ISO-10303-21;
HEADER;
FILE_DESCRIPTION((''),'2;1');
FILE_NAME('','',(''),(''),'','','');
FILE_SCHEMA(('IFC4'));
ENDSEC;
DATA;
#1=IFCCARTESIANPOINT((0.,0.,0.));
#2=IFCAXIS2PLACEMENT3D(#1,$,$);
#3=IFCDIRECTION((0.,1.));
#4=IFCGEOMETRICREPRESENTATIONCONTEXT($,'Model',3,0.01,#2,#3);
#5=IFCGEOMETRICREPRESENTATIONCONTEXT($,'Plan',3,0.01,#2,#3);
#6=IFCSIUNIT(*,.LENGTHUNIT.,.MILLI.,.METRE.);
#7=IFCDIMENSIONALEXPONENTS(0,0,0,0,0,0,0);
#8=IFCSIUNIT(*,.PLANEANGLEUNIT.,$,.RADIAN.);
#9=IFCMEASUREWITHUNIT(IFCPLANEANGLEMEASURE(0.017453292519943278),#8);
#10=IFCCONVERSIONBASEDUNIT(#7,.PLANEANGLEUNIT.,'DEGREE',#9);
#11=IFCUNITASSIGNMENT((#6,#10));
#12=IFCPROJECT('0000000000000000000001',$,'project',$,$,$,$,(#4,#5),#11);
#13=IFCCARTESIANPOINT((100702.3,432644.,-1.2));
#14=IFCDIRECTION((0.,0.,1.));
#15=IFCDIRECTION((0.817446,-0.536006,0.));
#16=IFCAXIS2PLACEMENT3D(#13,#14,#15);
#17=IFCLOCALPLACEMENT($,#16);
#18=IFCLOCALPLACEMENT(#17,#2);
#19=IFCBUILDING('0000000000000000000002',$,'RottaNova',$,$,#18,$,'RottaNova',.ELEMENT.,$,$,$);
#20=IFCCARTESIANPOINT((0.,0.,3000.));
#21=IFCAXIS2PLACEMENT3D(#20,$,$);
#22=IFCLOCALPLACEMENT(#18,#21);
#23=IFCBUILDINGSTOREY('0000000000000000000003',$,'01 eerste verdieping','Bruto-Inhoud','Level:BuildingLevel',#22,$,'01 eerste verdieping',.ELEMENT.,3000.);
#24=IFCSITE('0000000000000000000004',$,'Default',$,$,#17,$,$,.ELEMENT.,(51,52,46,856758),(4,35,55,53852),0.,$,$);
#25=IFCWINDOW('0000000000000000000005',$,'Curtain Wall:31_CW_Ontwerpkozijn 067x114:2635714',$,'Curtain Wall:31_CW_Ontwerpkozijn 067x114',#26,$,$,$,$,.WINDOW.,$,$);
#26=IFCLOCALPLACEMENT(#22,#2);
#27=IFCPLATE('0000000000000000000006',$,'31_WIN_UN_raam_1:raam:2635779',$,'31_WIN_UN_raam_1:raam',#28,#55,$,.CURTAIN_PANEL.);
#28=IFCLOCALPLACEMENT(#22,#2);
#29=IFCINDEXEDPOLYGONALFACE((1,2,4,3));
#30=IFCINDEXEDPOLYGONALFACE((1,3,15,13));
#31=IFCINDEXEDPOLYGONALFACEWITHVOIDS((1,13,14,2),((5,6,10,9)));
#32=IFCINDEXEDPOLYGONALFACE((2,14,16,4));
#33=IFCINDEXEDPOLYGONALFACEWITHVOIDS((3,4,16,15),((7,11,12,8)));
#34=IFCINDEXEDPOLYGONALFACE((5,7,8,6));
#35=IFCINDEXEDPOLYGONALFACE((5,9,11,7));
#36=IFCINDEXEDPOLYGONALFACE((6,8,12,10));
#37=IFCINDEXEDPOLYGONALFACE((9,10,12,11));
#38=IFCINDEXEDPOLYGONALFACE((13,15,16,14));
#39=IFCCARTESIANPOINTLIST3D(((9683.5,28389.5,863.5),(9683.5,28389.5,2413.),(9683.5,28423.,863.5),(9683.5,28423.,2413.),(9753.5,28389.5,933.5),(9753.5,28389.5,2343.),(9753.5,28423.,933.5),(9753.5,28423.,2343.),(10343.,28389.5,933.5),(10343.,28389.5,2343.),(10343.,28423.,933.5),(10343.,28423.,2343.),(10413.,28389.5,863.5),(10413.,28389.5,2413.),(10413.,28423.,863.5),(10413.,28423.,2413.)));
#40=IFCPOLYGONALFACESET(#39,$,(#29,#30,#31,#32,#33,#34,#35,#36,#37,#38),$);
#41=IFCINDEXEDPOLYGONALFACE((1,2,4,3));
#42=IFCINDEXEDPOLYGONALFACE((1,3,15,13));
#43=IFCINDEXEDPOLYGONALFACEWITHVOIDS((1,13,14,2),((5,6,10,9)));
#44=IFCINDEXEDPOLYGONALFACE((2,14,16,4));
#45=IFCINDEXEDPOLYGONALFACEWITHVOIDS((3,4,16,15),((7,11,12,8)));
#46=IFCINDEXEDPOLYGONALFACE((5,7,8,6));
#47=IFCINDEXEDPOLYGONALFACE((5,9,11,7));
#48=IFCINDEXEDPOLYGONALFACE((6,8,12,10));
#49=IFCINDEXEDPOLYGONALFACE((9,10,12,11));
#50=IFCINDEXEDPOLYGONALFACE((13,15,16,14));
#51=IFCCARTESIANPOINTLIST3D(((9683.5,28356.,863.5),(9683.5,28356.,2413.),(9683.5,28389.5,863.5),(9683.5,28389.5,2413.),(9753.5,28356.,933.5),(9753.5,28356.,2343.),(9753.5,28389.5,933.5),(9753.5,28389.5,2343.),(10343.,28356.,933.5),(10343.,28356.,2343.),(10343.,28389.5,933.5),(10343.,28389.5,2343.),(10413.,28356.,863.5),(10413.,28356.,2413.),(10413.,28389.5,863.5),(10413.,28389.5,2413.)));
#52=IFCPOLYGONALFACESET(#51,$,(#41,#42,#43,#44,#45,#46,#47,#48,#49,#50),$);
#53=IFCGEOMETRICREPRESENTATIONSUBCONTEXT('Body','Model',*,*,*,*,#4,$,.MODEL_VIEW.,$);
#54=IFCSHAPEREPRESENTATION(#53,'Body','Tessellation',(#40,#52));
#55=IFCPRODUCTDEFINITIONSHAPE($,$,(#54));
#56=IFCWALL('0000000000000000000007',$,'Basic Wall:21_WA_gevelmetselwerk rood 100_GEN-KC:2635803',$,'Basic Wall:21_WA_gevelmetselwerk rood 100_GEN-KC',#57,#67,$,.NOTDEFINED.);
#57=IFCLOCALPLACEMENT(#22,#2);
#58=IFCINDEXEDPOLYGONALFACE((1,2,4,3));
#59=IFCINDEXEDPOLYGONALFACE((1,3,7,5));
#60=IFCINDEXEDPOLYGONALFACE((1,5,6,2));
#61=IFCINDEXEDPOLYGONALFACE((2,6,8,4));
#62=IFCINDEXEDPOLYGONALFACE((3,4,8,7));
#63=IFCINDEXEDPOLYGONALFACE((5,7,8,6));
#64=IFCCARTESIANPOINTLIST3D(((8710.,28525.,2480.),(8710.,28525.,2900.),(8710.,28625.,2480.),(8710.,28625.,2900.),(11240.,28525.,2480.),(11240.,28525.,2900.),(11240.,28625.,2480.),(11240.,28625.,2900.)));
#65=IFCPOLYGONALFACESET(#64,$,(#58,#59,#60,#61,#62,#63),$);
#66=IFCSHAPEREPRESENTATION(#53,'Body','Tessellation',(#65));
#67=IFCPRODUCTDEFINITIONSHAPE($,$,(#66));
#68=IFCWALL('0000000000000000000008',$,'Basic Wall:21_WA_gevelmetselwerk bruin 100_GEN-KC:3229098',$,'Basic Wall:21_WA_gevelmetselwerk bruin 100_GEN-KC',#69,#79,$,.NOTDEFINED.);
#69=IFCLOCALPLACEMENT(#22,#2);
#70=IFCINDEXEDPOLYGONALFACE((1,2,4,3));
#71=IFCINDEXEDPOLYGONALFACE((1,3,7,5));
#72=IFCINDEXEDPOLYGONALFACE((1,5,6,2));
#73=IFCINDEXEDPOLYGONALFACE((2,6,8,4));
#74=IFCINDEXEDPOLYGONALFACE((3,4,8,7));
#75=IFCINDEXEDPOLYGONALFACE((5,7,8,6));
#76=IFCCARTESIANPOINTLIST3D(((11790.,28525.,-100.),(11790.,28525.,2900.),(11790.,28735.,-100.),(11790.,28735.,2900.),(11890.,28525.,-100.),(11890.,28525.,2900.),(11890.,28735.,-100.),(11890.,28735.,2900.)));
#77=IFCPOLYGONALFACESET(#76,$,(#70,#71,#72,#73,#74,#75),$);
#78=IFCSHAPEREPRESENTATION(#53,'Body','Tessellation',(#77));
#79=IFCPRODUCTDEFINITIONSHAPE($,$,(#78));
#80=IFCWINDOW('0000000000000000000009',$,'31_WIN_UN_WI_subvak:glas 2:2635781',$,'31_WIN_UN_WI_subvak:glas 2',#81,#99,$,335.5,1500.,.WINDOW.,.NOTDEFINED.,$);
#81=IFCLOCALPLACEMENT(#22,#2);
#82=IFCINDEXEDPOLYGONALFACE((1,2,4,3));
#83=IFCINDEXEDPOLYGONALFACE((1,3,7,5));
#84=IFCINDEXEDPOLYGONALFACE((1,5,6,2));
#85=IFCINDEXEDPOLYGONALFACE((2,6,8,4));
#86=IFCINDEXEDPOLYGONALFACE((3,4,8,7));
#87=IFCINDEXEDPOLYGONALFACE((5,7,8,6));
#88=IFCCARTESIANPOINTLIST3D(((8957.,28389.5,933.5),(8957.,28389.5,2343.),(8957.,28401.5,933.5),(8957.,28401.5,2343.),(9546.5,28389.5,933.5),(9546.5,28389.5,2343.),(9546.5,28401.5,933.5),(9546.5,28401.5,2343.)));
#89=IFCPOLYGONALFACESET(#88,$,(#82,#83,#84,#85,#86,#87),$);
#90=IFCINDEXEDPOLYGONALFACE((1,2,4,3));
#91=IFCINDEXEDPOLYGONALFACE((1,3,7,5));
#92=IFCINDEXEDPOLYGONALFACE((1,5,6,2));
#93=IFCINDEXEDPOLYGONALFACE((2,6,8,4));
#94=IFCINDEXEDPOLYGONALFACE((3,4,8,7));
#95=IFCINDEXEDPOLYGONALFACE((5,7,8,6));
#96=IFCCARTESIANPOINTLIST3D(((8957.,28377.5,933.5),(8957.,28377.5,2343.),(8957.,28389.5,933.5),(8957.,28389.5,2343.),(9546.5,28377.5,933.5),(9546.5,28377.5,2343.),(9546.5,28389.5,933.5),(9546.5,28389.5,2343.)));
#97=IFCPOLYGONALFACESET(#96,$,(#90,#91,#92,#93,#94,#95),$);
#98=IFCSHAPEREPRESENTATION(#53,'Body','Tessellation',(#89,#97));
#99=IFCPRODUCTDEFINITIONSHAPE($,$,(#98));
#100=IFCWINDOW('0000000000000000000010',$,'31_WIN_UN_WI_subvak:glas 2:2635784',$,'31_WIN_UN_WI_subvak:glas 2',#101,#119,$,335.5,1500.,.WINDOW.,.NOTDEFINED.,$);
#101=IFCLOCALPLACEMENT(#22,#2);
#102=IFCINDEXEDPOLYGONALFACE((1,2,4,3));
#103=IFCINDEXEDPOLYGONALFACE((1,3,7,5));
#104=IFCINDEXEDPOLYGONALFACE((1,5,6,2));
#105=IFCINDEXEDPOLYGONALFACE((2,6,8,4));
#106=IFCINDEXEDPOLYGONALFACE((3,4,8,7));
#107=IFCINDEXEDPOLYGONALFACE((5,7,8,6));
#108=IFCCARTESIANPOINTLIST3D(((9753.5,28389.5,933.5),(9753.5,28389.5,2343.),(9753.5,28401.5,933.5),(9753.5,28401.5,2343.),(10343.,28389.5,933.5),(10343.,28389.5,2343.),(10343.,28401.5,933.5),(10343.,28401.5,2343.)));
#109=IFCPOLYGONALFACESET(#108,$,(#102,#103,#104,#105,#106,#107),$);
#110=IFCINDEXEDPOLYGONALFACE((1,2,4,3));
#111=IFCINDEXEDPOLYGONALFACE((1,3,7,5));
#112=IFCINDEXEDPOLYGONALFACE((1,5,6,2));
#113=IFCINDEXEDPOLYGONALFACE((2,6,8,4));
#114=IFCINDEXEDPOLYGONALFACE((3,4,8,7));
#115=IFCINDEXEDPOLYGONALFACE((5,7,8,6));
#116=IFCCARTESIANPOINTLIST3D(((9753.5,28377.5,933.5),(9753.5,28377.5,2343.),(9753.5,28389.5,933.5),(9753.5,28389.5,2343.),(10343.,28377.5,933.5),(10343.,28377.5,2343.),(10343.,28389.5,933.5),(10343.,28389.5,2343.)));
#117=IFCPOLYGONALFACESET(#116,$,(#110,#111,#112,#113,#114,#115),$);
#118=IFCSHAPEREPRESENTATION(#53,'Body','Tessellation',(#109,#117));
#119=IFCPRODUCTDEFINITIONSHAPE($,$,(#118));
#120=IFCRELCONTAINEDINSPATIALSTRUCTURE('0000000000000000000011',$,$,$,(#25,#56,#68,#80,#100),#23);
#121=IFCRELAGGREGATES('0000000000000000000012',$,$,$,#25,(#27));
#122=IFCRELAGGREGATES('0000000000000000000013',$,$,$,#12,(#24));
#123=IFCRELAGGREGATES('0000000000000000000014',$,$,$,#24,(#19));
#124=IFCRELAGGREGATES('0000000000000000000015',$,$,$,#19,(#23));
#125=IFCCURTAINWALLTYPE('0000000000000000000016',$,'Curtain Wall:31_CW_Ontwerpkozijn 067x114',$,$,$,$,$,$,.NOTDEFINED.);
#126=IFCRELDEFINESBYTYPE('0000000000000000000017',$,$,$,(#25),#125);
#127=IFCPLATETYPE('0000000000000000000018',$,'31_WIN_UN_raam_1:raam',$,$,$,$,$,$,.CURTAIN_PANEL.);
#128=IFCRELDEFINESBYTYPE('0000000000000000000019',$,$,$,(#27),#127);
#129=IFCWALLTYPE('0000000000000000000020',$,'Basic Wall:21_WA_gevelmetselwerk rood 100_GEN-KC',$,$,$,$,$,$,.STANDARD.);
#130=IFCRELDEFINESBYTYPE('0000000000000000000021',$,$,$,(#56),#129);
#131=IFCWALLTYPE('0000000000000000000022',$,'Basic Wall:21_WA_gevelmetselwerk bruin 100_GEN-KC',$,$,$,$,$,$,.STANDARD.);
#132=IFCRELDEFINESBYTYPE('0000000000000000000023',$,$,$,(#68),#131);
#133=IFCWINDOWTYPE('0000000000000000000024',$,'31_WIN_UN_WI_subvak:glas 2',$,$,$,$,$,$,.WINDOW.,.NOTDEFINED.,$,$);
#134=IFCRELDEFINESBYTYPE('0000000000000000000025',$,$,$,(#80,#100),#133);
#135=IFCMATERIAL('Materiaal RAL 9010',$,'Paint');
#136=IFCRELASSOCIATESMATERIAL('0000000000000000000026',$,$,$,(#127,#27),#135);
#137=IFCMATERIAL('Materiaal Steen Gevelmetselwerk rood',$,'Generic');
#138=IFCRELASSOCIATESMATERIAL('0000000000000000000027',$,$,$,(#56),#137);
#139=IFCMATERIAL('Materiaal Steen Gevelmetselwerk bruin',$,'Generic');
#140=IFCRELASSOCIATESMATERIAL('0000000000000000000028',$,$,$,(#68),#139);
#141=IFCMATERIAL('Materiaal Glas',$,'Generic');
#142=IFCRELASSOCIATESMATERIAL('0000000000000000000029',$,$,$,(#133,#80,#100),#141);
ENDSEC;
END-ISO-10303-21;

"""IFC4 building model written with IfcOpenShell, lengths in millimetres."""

from ifc_helpers import new_model, entity, si_unit, converted_unit, direction, frame, origin, place, context, subcontext, project, spatial, indexed_curve, outline, extrude, source, transform, mapped, material, type_object, type_shapes, element, aggregate, save


model = new_model("IFC4")

# Units and contexts
model_context = context("Model", 3, precision=0.01, world=origin(), true_north=direction((0.0, 1.0)))
plan_context = context("Plan", 3, precision=0.01, world=origin(), true_north=direction((0.0, 1.0)))
body_context = subcontext(model_context, "Body", "Model", "MODEL_VIEW")
ifc_project = project(units=[si_unit("LENGTHUNIT", "METRE", prefix="MILLI"), converted_unit("PLANEANGLEUNIT", "DEGREE", entity("IfcPlaneAngleMeasure", 0.017453292519943278), si_unit("PLANEANGLEUNIT", "RADIAN"), dimensions=[0, 0, 0, 0, 0, 0, 0])], contexts=[model_context, plan_context])

# Site, building, storey
site_placement = place(None, frame((100702.3, 432644.0, -1.2), z_axis=(0.0, 0.0, 1.0), x_axis=(0.817446, -0.536006, 0.0)))
site = spatial("IfcSite", under=ifc_project, at=site_placement, Name="Default", CompositionType="ELEMENT", RefLatitude=(51, 52, 46, 856758), RefLongitude=(4, 35, 55, 53852), RefElevation=0.0)
building_placement = place(site_placement, origin())
building = spatial("IfcBuilding", under=site, at=building_placement, Name="RottaNova", LongName="RottaNova", CompositionType="ELEMENT")
storey_placement = place(building_placement, frame((0.0, 0.0, 3000.0)))
storey = spatial("IfcBuildingStorey", under=building, at=storey_placement, Name="01 eerste verdieping", Description="Bruto-Inhoud", ObjectType="Level:BuildingLevel", LongName="01 eerste verdieping", CompositionType="ELEMENT", Elevation=3000.0)

# Shared definitions
curtain_wall_type = type_object("IfcCurtainWallType", Name="Curtain Wall:31_CW_Ontwerpkozijn 067x114", PredefinedType="NOTDEFINED")

# Window
window_1_placement = place(storey_placement, frame((0.0, 0.0, -3000.0)))
window_1 = element("IfcWindow", 1, at=window_1_placement, inside=storey, type_object=curtain_wall_type, Name="Curtain Wall:31_CW_Ontwerpkozijn 067x114:2635714", ObjectType="Curtain Wall:31_CW_Ontwerpkozijn 067x114", PredefinedType="WINDOW")

# Plate
ifc_material_1 = material(Name="Materiaal Glas", Category="Generic")
ifc_material_2 = material(Name="Materiaal RAL 9010", Category="Paint")
plate_type_1 = type_object("IfcPlateType", Name="31_WIN_UN_raam_1:raam", PredefinedType="CURTAIN_PANEL", material=ifc_material_2)
shared_shape_1 = source(origin(), body_context, "Body", "SweptSolid", [
    extrude(outline(indexed_curve([(-364.7, -774.7), (364.7, -774.7), (364.7, 774.7), (-364.7, 774.7), (-364.7, -774.7)], self_intersect=False), holes=[indexed_curve([(-294.7, 704.7), (294.7, 704.7), (294.7, -704.8), (-294.7, -704.8), (-294.7, 704.7)], self_intersect=False)]), frame((0.0, 58.5, 774.8), z_axis=(0.0, 1.0, 0.0), x_axis=(1.0, 0.0, 0.0)), (0.0, 0.0, 1.0), 33.5),
    extrude(outline(indexed_curve([(-364.7, -774.7), (364.7, -774.7), (364.7, 774.7), (-364.7, 774.7), (-364.7, -774.7)], self_intersect=False), holes=[indexed_curve([(-294.7, 704.7), (294.7, 704.7), (294.7, -704.8), (-294.7, -704.8), (-294.7, 704.7)], self_intersect=False)]), frame((0.0, 25.0, 774.8), z_axis=(0.0, 1.0, 0.0), x_axis=(1.0, 0.0, 0.0)), (0.0, 0.0, 1.0), 33.5),
])
type_shapes(plate_type_1, [shared_shape_1])
plate_1_placement = place(window_1_placement, frame((10048.2, 28331.0, 3863.5)))
plate_1 = element("IfcPlate", 2, at=plate_1_placement, type_object=plate_type_1, material=ifc_material_2, Name="31_WIN_UN_raam_1:raam:2635779", ObjectType="31_WIN_UN_raam_1:raam", PredefinedType="CURTAIN_PANEL", context=body_context, shape_type="MappedRepresentation", body=[
    mapped(shared_shape_1, transform((0.0, 0.0, 0.0), scale=1.0)),
])
aggregate(window_1, [plate_1])

# Walls
ifc_material_3 = material(Name="Materiaal Steen Gevelmetselwerk rood", Category="Generic")
wall_type_1 = type_object("IfcWallType", Name="Basic Wall:21_WA_gevelmetselwerk rood 100_GEN-KC", PredefinedType="STANDARD")
wall_1_placement = place(storey_placement, frame((8710.0, 28575.0, 2480.0)))
element("IfcWall", 3, at=wall_1_placement, inside=storey, type_object=wall_type_1, material=ifc_material_3, Name="Basic Wall:21_WA_gevelmetselwerk rood 100_GEN-KC:2635803", ObjectType="Basic Wall:21_WA_gevelmetselwerk rood 100_GEN-KC", PredefinedType="NOTDEFINED", context=body_context, shape_type="SweptSolid", body=[
    extrude(outline(indexed_curve([(2530.0, 50.0), (0.0, 50.0), (0.0, -50.0), (2530.0, -50.0), (2530.0, 50.0)], self_intersect=False)), origin(), (0.0, 0.0, 1.0), 420.0),
])
ifc_material_4 = material(Name="Materiaal Steen Gevelmetselwerk bruin", Category="Generic")
wall_type_2 = type_object("IfcWallType", Name="Basic Wall:21_WA_gevelmetselwerk bruin 100_GEN-KC", PredefinedType="STANDARD")
wall_2_placement = place(storey_placement, frame((11840.0, 28735.0, -100.0), z_axis=(0.0, 0.0, 1.0), x_axis=(0.0, -1.0, 0.0)))
element("IfcWall", 4, at=wall_2_placement, inside=storey, type_object=wall_type_2, material=ifc_material_4, Name="Basic Wall:21_WA_gevelmetselwerk bruin 100_GEN-KC:3229098", ObjectType="Basic Wall:21_WA_gevelmetselwerk bruin 100_GEN-KC", PredefinedType="NOTDEFINED", context=body_context, shape_type="SweptSolid", body=[
    extrude(outline(indexed_curve([(210.0, 50.0), (0.0, 50.0), (0.0, -50.0), (210.0, -50.0), (210.0, 50.0)], self_intersect=False)), origin(), (0.0, 0.0, 1.0), 3000.0),
])

# Windows
window_type = type_object("IfcWindowType", Name="31_WIN_UN_WI_subvak:glas 2", PartitioningType="NOTDEFINED", PredefinedType="WINDOW", material=ifc_material_1)
shared_shape_2 = source(origin(), body_context, "Body", "SweptSolid", [
    extrude(outline(indexed_curve([(-6.0, -294.7), (6.0, -294.7), (6.0, 294.7), (-6.0, 294.7), (-6.0, -294.7)], self_intersect=False)), frame((0.0, 6.0, 0.0), z_axis=(0.0, 0.0, 1.0), x_axis=(0.0, -1.0, 0.0)), (0.0, 0.0, 1.0), 1409.5),
    extrude(outline(indexed_curve([(-6.0, -294.8), (6.0, -294.8), (6.0, 294.8), (-6.0, 294.8), (-6.0, -294.8)], self_intersect=False)), frame((0.0, -6.0, 0.0), z_axis=(0.0, 0.0, 1.0), x_axis=(0.0, -1.0, 0.0)), (0.0, 0.0, 1.0), 1409.5),
])
type_shapes(window_type, [shared_shape_2])
for number, where, name in (
    (5, (9251.7, 28389.5, 933.5), "31_WIN_UN_WI_subvak:glas 2:2635781"),
    (6, (10048.2, 28389.5, 933.5), "31_WIN_UN_WI_subvak:glas 2:2635784"),
):
    element("IfcWindow", number, at=place(storey_placement, frame(where)), inside=storey, type_object=window_type, material=ifc_material_1, Name=name, ObjectType="31_WIN_UN_WI_subvak:glas 2", OverallHeight=335.5, OverallWidth=1500.0, PartitioningType="NOTDEFINED", PredefinedType="WINDOW", context=body_context, shape_type="MappedRepresentation", body=[
        mapped(shared_shape_2, transform((0.0, 0.0, 0.0), scale=1.0)),
    ])

save(model, "model.ifc")
